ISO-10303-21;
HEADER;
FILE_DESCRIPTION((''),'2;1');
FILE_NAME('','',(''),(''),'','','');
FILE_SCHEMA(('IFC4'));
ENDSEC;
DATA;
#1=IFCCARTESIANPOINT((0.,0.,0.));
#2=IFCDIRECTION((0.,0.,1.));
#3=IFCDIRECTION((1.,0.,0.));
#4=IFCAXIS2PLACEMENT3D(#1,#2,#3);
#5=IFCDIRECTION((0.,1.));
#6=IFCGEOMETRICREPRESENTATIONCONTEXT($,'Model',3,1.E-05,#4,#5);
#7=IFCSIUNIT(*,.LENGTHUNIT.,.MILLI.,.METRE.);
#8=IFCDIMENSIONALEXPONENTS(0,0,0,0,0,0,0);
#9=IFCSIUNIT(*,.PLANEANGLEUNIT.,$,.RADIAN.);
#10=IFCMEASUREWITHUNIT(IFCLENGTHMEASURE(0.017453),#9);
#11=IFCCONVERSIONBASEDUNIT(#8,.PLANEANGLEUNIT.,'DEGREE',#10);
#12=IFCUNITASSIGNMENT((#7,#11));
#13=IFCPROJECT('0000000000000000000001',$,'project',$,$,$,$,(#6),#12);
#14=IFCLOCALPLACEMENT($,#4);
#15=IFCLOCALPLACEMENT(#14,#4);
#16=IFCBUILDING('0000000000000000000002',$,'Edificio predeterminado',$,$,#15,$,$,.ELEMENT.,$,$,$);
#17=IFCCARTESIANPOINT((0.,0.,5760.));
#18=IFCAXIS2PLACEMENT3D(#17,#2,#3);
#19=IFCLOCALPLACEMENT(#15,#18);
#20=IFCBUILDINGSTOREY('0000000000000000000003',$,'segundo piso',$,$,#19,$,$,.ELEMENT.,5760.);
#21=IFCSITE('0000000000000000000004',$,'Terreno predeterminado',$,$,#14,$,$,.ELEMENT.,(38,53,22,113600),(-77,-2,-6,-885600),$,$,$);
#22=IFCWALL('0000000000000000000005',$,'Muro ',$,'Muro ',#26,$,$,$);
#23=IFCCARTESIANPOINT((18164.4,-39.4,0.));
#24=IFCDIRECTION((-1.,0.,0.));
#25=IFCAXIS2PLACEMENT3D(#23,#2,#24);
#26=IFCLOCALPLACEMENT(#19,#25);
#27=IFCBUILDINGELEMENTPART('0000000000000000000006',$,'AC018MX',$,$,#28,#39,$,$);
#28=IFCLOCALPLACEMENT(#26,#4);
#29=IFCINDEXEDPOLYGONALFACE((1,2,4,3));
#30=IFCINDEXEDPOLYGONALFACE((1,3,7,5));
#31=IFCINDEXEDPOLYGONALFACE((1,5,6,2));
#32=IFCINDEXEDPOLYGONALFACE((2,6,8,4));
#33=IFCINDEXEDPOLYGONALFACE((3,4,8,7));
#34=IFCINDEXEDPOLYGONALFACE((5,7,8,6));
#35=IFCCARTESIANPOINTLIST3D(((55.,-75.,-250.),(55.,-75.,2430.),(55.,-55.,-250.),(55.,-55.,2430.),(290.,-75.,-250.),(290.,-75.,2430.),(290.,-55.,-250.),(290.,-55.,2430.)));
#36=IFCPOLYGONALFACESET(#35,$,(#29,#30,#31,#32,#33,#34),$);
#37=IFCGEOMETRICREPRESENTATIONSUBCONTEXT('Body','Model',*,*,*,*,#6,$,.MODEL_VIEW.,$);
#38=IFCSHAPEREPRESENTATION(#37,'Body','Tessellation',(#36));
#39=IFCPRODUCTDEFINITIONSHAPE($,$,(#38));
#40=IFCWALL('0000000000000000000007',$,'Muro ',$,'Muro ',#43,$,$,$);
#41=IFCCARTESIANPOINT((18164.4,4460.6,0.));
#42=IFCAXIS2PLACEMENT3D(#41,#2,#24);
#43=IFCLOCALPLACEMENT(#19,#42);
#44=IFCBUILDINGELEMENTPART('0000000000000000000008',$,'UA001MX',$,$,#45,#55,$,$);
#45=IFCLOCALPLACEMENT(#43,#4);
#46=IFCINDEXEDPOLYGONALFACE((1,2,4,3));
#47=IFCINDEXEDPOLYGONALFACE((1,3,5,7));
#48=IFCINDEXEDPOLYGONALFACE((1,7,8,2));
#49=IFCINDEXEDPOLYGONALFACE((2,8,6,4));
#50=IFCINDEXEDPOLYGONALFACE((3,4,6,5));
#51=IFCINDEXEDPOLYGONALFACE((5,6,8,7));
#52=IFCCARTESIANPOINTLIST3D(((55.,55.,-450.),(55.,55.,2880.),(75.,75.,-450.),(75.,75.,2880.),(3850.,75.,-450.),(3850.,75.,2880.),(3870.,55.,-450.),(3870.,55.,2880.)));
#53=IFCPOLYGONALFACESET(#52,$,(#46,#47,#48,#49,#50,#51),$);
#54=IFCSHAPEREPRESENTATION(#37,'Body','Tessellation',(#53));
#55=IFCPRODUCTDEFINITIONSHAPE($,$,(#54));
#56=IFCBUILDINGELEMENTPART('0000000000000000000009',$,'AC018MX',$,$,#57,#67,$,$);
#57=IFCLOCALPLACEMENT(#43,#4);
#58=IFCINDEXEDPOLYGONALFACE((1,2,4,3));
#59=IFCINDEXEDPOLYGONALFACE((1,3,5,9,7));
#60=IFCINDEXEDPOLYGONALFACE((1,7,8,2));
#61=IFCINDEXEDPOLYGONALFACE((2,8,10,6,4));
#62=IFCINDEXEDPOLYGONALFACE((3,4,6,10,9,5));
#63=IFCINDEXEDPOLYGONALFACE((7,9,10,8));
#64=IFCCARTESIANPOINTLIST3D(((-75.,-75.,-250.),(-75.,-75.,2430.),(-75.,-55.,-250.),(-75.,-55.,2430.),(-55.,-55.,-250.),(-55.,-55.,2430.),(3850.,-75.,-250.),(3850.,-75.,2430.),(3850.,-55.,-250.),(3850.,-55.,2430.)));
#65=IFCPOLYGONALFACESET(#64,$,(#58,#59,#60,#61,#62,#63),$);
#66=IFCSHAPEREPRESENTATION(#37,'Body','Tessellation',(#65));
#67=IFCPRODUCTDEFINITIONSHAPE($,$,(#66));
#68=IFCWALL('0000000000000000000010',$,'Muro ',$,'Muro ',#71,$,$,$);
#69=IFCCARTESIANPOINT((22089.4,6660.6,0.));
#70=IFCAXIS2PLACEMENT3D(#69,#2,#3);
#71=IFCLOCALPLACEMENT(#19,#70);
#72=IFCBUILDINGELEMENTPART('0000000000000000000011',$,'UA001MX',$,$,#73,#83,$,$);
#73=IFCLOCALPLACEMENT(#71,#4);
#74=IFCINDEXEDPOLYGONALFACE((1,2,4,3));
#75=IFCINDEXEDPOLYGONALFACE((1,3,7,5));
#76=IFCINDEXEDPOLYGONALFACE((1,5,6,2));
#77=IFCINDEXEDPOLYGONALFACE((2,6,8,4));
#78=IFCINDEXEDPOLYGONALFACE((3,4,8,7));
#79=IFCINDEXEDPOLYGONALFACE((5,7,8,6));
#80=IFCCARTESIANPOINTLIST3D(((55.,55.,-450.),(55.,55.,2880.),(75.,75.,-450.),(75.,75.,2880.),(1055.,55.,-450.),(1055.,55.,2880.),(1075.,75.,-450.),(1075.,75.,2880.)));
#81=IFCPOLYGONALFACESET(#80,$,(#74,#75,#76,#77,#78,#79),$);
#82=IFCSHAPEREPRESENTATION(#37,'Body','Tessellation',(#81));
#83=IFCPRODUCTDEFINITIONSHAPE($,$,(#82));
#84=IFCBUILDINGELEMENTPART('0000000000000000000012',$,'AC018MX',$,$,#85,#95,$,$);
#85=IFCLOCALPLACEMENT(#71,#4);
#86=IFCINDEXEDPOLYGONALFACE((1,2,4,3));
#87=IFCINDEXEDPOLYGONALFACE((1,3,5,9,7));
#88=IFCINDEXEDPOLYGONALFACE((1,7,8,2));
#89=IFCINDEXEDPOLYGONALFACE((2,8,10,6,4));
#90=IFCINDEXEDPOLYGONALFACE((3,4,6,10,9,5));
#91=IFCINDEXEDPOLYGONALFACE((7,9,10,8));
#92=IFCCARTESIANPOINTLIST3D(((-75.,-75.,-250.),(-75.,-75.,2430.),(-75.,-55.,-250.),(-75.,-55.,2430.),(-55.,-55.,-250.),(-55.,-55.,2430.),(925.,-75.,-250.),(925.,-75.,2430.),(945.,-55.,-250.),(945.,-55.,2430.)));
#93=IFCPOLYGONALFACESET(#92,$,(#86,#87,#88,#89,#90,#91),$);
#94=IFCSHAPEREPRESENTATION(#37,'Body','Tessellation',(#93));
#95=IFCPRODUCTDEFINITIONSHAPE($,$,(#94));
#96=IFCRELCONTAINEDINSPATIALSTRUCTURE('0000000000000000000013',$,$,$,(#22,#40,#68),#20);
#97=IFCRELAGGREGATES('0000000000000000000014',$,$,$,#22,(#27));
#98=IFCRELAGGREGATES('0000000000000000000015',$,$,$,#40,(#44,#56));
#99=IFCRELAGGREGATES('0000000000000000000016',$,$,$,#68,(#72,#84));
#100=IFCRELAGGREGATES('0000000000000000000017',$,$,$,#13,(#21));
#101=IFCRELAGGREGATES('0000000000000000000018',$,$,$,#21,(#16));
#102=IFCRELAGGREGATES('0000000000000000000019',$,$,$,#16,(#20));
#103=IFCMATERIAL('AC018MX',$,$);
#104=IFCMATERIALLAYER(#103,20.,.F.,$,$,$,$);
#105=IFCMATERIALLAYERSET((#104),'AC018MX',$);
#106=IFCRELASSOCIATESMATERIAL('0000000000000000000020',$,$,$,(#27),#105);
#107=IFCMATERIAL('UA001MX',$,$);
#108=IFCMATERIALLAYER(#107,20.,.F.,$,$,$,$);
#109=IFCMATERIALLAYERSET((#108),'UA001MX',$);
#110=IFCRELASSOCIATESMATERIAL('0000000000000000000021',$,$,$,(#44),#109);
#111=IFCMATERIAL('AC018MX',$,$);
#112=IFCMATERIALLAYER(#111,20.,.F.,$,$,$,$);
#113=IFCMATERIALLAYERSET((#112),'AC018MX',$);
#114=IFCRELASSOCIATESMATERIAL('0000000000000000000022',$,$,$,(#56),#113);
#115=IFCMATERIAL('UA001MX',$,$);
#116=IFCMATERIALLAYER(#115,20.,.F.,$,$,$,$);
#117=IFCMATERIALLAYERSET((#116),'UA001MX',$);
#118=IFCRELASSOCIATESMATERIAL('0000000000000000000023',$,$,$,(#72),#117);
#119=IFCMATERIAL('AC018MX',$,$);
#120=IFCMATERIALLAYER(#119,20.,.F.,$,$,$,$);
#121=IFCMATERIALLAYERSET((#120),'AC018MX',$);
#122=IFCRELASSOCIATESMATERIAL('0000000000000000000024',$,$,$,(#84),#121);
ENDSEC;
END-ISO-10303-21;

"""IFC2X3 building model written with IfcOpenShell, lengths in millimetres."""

from ifc_helpers import new_model, entity, si_unit, converted_unit, direction, frame, origin_with_axes, place, context, subcontext, project, spatial, polyline, outline, extrude, material, layer, layer_set, layer_usage, element, aggregate, save


model = new_model("IFC2X3")

# Units and contexts
model_context = context("Model", 3, precision=1e-05, world=origin_with_axes(), true_north=direction((0.0, 1.0)))
body_context = subcontext(model_context, "Body", "Model", "MODEL_VIEW")
ifc_project = project(units=[si_unit("LENGTHUNIT", "METRE", prefix="MILLI"), converted_unit("PLANEANGLEUNIT", "DEGREE", entity("IfcLengthMeasure", 0.017453), si_unit("PLANEANGLEUNIT", "RADIAN"), dimensions=[0, 0, 0, 0, 0, 0, 0])], contexts=[model_context])

# Site, building, storey
site_placement = place(None, origin_with_axes())
site = spatial("IfcSite", under=ifc_project, at=site_placement, Name="Terreno predeterminado", CompositionType="ELEMENT", RefLatitude=(38, 53, 22, 113600), RefLongitude=(-77, -2, -6, -885600))
building_placement = place(site_placement, origin_with_axes())
building = spatial("IfcBuilding", under=site, at=building_placement, Name="Edificio predeterminado", CompositionType="ELEMENT")
storey_placement = place(building_placement, frame((0.0, 0.0, 5760.0), z_axis=(0.0, 0.0, 1.0), x_axis=(1.0, 0.0, 0.0)))
storey = spatial("IfcBuildingStorey", under=building, at=storey_placement, Name="segundo piso", CompositionType="ELEMENT", Elevation=5760.0)

# Wall, building element part
wall_1_placement = place(storey_placement, frame((18164.4, -39.4, 0.0), z_axis=(0.0, 0.0, 1.0), x_axis=(-1.0, 0.0, 0.0)))
wall_1 = element("IfcWall", 1, at=wall_1_placement, inside=storey, Name="Muro ", ObjectType="Muro ")
ifc_material_1 = material(Name="AC018MX")
ifc_layer_1 = layer(ifc_material_1, 20.0, ventilated=False)
ifc_layer_set_1 = layer_set([ifc_layer_1], Name="AC018MX")
ifc_layer_usage_1 = layer_usage(ifc_layer_set_1, "AXIS2", "NEGATIVE", 55.0)
building_element_part_1_placement = place(wall_1_placement, origin_with_axes())
building_element_part_1 = element("IfcBuildingElementPart", 2, at=building_element_part_1_placement, material=ifc_layer_usage_1, Name="AC018MX", context=body_context, shape_type="SweptSolid", body=[
    extrude(outline(polyline([(290.0, -55.0), (290.0, -75.0), (55.0, -75.0), (55.0, -55.0), (290.0, -55.0)])), frame((0.0, 0.0, -250.0), z_axis=(0.0, 0.0, 1.0), x_axis=(1.0, 0.0, 0.0)), (0.0, 0.0, 1.0), 2680.0),
])
aggregate(wall_1, [building_element_part_1])

# Walls, building element parts
wall_2_placement = place(storey_placement, frame((18164.4, 4460.6, 0.0), z_axis=(0.0, 0.0, 1.0), x_axis=(-1.0, 0.0, 0.0)))
wall_2 = element("IfcWall", 3, at=wall_2_placement, inside=storey, Name="Muro ", ObjectType="Muro ")
ifc_material_2 = material(Name="UA001MX")
ifc_layer_2 = layer(ifc_material_2, 20.0, ventilated=False)
ifc_layer_set_2 = layer_set([ifc_layer_2], Name="UA001MX")
ifc_layer_usage_2 = layer_usage(ifc_layer_set_2, "AXIS2", "NEGATIVE", -75.0)
building_element_part_2_placement = place(wall_2_placement, origin_with_axes())
building_element_part_2 = element("IfcBuildingElementPart", 4, at=building_element_part_2_placement, material=ifc_layer_usage_2, Name="UA001MX", context=body_context, shape_type="SweptSolid", body=[
    extrude(outline(polyline([(3850.0, 75.0), (3870.0, 55.0), (55.0, 55.0), (75.0, 75.0), (3850.0, 75.0)])), frame((0.0, 0.0, -450.0), z_axis=(0.0, 0.0, 1.0), x_axis=(1.0, 0.0, 0.0)), (0.0, 0.0, 1.0), 3330.0),
])
ifc_material_3 = material(Name="AC018MX")
ifc_layer_3 = layer(ifc_material_3, 20.0, ventilated=False)
ifc_layer_set_3 = layer_set([ifc_layer_3], Name="AC018MX")
ifc_layer_usage_3 = layer_usage(ifc_layer_set_3, "AXIS2", "NEGATIVE", 55.0)
building_element_part_3_placement = place(wall_2_placement, origin_with_axes())
building_element_part_3 = element("IfcBuildingElementPart", 5, at=building_element_part_3_placement, material=ifc_layer_usage_3, Name="AC018MX", context=body_context, shape_type="SweptSolid", body=[
    extrude(outline(polyline([(3850.0, -55.0), (3850.0, -75.0), (-75.0, -75.0), (-75.0, -55.0), (-55.0, -55.0), (3850.0, -55.0)])), frame((0.0, 0.0, -250.0), z_axis=(0.0, 0.0, 1.0), x_axis=(1.0, 0.0, 0.0)), (0.0, 0.0, 1.0), 2680.0),
])
aggregate(wall_2, [building_element_part_2, building_element_part_3])
wall_3_placement = place(storey_placement, frame((22089.4, 6660.6, 0.0), z_axis=(0.0, 0.0, 1.0), x_axis=(1.0, 0.0, 0.0)))
wall_3 = element("IfcWall", 6, at=wall_3_placement, inside=storey, Name="Muro ", ObjectType="Muro ")
ifc_material_4 = material(Name="UA001MX")
ifc_layer_4 = layer(ifc_material_4, 20.0, ventilated=False)
ifc_layer_set_4 = layer_set([ifc_layer_4], Name="UA001MX")
ifc_layer_usage_4 = layer_usage(ifc_layer_set_4, "AXIS2", "NEGATIVE", -75.0)
building_element_part_4_placement = place(wall_3_placement, origin_with_axes())
building_element_part_4 = element("IfcBuildingElementPart", 7, at=building_element_part_4_placement, material=ifc_layer_usage_4, Name="UA001MX", context=body_context, shape_type="SweptSolid", body=[
    extrude(outline(polyline([(1075.0, 75.0), (1055.0, 55.0), (55.0, 55.0), (75.0, 75.0), (1075.0, 75.0)])), frame((0.0, 0.0, -450.0), z_axis=(0.0, 0.0, 1.0), x_axis=(1.0, 0.0, 0.0)), (0.0, 0.0, 1.0), 3330.0),
])
ifc_material_5 = material(Name="AC018MX")
ifc_layer_5 = layer(ifc_material_5, 20.0, ventilated=False)
ifc_layer_set_5 = layer_set([ifc_layer_5], Name="AC018MX")
ifc_layer_usage_5 = layer_usage(ifc_layer_set_5, "AXIS2", "NEGATIVE", 55.0)
building_element_part_5_placement = place(wall_3_placement, origin_with_axes())
building_element_part_5 = element("IfcBuildingElementPart", 8, at=building_element_part_5_placement, material=ifc_layer_usage_5, Name="AC018MX", context=body_context, shape_type="SweptSolid", body=[
    extrude(outline(polyline([(945.0, -55.0), (925.0, -75.0), (-75.0, -75.0), (-75.0, -55.0), (-55.0, -55.0), (945.0, -55.0)])), frame((0.0, 0.0, -250.0), z_axis=(0.0, 0.0, 1.0), x_axis=(1.0, 0.0, 0.0)), (0.0, 0.0, 1.0), 2680.0),
])
aggregate(wall_3, [building_element_part_4, building_element_part_5])

save(model, "model.ifc")
